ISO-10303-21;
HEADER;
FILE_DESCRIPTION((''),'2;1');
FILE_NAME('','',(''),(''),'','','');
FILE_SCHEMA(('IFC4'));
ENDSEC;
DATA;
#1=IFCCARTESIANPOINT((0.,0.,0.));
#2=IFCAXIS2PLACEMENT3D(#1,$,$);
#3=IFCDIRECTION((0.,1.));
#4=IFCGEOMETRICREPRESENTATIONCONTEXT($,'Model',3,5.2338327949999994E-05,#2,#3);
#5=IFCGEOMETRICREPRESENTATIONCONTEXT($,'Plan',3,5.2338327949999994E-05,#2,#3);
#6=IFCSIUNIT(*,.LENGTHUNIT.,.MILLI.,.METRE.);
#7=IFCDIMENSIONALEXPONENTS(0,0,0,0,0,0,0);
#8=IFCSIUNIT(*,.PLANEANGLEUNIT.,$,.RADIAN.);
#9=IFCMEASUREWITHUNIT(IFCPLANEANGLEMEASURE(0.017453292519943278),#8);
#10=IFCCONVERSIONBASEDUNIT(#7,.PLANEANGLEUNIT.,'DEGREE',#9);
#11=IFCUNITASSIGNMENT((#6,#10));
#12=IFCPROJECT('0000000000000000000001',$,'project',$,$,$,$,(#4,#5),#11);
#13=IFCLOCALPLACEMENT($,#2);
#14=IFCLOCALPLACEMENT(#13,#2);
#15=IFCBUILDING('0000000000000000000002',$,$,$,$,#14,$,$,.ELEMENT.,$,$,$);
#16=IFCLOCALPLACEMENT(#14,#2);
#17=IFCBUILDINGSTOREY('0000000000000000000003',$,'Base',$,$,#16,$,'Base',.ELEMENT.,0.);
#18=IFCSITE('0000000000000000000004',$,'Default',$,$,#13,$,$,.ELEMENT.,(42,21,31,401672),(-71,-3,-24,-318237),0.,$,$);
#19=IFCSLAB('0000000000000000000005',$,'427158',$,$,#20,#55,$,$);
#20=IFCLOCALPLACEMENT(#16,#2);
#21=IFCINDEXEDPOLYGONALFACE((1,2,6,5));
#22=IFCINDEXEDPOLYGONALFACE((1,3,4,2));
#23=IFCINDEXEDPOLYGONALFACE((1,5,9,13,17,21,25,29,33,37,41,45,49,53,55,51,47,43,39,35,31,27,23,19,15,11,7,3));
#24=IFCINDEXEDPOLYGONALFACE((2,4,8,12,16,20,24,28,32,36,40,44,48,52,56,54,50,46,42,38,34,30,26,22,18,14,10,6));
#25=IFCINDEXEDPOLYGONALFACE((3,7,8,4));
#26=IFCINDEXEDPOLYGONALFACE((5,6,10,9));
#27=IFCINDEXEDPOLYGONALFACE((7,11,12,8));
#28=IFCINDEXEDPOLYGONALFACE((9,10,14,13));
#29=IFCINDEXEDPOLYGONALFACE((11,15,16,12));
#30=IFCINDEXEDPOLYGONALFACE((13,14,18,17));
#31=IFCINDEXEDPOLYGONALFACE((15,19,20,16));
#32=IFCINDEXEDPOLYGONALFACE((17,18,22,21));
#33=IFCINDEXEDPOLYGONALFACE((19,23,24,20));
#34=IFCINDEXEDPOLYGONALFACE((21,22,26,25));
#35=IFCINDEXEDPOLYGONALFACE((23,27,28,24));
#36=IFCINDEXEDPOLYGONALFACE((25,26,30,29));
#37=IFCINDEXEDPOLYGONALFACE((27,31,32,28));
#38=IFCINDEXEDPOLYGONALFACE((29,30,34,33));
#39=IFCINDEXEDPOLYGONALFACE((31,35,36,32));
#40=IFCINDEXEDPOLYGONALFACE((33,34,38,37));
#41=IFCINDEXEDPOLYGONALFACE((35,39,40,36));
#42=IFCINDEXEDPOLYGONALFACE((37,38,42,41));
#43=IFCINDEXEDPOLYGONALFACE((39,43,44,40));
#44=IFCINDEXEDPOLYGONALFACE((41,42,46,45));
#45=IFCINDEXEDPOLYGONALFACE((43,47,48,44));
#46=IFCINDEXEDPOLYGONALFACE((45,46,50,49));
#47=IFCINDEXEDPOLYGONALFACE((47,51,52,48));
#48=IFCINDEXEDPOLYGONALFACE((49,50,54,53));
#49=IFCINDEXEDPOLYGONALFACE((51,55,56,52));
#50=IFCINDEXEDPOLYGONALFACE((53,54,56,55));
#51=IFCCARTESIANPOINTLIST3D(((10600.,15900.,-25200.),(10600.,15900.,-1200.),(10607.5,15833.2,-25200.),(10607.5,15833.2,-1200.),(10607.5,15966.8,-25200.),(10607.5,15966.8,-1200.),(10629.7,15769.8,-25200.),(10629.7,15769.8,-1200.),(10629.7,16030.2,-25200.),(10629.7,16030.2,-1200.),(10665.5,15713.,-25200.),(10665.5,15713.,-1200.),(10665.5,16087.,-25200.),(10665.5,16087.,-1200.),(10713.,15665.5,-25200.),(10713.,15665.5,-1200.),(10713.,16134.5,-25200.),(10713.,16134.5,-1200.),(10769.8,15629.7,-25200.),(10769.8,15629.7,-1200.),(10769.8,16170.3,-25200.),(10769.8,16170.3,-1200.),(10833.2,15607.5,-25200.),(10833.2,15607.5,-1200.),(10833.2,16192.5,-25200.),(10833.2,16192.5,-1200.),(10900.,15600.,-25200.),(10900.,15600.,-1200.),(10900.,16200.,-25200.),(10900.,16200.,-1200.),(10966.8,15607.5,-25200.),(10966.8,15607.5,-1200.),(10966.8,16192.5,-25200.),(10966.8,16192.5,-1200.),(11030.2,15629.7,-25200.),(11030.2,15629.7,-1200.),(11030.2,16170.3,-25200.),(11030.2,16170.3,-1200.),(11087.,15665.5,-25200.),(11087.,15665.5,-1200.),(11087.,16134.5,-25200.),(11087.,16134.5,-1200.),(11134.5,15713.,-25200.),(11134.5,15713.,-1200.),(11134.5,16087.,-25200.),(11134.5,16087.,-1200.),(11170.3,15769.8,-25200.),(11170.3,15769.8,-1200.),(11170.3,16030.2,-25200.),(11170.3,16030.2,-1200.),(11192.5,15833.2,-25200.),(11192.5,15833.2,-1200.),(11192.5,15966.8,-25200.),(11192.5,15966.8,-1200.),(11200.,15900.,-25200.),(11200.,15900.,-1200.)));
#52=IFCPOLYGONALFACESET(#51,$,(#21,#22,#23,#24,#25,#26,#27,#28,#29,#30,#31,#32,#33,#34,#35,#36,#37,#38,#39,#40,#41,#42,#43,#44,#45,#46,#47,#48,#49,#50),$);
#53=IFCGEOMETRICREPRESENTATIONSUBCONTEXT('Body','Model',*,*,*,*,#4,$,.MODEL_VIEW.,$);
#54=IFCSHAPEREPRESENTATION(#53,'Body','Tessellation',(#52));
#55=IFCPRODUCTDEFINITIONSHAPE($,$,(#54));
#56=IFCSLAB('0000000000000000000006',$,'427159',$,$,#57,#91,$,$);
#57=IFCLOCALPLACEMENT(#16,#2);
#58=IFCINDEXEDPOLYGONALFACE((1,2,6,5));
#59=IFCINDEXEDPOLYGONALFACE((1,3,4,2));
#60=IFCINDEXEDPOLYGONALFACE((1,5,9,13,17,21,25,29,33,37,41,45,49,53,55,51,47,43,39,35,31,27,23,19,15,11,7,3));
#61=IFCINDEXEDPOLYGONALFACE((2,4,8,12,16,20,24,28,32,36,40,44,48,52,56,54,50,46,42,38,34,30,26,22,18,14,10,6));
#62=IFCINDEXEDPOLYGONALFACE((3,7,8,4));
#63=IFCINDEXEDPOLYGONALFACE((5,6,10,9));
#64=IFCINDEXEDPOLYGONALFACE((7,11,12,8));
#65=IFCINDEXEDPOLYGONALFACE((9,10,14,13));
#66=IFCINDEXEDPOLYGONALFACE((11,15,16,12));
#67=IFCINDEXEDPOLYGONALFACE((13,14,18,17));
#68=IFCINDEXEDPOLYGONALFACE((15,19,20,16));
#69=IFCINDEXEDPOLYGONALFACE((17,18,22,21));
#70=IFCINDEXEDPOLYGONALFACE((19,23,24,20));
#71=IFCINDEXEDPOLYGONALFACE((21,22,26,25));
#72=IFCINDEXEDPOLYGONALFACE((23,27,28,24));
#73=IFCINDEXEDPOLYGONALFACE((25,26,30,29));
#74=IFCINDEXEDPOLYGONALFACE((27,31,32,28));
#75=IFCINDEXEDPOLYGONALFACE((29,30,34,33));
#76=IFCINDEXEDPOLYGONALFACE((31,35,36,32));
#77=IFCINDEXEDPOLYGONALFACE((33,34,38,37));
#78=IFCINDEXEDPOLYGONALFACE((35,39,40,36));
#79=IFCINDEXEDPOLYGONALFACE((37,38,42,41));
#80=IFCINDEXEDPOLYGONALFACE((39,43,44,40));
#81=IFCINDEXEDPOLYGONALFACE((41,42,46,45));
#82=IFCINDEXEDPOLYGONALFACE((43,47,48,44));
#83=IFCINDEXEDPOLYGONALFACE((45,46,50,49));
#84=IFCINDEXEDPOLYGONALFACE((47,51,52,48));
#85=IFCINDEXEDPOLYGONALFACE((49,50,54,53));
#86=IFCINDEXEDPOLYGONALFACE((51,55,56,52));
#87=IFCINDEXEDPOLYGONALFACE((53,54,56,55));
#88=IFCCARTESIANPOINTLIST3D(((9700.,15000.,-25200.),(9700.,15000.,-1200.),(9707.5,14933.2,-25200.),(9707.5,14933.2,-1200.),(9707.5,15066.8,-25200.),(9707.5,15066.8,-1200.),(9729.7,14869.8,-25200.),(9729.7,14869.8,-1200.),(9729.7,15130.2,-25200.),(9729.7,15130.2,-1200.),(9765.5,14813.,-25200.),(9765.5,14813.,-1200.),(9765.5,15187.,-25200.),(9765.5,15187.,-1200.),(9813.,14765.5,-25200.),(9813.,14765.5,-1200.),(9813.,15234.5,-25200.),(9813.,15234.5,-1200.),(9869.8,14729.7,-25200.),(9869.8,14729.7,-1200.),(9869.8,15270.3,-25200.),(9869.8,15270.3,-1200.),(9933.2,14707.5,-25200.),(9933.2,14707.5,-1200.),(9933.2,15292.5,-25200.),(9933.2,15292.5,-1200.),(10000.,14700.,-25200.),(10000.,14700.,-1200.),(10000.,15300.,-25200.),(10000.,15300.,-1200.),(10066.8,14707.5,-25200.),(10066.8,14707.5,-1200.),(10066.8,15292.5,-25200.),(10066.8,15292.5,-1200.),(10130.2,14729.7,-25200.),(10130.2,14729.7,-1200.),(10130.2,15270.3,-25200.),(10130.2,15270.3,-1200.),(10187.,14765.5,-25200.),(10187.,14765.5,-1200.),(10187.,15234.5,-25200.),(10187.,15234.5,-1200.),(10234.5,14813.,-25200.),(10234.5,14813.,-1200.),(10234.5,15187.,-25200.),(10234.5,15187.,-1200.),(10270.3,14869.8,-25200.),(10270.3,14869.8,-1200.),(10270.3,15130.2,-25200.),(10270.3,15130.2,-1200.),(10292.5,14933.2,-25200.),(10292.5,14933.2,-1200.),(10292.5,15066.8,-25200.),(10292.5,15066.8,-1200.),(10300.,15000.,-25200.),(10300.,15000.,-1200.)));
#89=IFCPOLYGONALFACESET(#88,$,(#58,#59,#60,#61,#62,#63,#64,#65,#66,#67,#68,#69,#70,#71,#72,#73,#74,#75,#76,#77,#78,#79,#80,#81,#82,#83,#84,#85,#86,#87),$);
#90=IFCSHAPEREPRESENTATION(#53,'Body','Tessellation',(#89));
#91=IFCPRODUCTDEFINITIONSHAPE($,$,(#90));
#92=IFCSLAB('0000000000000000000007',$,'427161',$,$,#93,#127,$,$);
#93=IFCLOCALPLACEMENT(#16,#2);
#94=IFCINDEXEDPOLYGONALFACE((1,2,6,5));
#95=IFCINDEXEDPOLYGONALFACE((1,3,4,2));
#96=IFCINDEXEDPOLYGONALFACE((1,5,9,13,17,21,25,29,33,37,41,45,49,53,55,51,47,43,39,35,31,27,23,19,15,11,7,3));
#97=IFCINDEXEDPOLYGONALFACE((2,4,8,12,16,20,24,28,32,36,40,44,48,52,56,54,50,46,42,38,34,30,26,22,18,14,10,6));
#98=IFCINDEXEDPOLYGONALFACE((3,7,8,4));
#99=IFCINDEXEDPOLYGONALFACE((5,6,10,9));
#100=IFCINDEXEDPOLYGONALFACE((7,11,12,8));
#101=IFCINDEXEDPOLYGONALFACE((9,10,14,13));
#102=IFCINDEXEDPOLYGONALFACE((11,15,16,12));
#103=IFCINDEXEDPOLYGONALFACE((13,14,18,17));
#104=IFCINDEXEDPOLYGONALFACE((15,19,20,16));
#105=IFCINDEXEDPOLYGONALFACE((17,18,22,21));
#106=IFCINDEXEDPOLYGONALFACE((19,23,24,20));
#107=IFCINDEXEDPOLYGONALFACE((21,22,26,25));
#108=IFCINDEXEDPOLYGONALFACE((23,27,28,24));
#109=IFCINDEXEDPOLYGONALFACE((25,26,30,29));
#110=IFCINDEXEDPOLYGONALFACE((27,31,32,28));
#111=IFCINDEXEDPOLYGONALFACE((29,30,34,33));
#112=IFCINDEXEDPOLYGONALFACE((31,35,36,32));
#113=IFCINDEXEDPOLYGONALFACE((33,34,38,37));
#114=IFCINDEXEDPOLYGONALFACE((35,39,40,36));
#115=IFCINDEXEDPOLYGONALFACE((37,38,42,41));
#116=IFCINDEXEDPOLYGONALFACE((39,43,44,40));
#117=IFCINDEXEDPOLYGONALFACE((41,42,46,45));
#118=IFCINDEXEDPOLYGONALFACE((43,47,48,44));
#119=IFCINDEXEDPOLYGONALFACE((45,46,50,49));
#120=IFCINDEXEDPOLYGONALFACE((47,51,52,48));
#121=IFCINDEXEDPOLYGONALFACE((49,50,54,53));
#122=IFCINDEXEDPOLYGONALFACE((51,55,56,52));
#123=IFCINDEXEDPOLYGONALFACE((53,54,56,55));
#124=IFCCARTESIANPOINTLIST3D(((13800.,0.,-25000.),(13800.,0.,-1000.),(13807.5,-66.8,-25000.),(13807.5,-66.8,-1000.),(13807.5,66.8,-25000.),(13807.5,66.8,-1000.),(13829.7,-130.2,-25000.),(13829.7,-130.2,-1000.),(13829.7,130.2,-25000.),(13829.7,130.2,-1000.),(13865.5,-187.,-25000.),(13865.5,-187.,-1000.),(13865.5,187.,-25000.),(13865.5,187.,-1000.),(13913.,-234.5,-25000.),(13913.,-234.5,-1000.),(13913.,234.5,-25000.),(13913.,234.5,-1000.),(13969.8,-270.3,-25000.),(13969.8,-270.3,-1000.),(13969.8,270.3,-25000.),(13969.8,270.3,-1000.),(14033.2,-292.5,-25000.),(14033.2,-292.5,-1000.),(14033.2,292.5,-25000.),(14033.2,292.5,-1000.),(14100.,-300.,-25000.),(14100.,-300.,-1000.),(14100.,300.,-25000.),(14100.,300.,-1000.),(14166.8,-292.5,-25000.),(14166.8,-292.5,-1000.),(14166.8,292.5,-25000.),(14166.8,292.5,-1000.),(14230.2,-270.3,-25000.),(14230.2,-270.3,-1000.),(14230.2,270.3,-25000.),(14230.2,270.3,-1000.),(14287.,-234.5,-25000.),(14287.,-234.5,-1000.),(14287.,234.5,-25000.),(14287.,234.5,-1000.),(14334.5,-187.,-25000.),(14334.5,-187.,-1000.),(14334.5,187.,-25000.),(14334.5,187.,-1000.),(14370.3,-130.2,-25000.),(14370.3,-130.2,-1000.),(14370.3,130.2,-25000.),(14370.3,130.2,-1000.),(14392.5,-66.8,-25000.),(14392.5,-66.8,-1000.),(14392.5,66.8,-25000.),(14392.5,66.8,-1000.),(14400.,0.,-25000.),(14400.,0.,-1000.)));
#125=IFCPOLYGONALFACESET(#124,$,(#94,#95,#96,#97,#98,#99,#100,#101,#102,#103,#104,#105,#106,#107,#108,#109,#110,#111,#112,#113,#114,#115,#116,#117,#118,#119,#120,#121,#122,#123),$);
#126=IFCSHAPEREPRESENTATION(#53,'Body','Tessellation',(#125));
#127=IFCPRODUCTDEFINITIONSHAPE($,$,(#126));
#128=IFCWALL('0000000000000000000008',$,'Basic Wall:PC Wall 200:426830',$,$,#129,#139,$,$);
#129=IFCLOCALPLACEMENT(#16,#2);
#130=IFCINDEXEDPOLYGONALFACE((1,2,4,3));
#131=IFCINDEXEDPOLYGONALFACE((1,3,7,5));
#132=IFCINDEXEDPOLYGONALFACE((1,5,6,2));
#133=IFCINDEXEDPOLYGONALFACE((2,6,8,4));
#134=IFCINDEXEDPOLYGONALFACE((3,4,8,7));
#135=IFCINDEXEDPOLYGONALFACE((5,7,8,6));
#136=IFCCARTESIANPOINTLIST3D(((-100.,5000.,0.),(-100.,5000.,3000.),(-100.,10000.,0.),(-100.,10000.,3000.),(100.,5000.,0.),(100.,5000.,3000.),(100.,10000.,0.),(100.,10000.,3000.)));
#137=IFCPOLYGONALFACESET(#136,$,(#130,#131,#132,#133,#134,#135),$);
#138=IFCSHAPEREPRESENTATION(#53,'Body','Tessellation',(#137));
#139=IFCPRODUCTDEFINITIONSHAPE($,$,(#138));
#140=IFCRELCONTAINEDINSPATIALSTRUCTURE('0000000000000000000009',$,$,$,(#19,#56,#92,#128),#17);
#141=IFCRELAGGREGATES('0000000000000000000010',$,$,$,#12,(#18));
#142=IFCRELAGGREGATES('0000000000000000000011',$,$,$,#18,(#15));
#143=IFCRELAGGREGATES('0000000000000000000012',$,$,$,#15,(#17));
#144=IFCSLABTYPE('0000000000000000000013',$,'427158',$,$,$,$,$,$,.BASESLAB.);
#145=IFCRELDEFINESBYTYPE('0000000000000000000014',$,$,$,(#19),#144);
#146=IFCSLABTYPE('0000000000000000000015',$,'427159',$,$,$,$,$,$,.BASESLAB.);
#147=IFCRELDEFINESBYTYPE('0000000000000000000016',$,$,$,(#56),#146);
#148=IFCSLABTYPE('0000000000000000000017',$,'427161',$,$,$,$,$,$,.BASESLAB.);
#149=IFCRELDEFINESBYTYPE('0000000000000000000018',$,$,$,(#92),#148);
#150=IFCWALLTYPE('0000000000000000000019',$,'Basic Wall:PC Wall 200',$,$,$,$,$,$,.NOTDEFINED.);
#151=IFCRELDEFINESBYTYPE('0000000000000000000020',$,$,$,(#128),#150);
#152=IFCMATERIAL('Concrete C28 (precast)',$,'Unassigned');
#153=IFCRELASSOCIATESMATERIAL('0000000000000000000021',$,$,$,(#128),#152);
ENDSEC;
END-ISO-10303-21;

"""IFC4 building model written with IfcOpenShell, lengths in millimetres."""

from ifc_helpers import new_model, entity, si_unit, converted_unit, direction, frame, origin, place, context, subcontext, project, spatial, arc, indexed_curve, outline, extrude, material, type_object, element, save


model = new_model("IFC4")

# Units and contexts
model_context = context("Model", 3, precision=5.2338327949999994e-05, world=origin(), true_north=direction((0.0, 1.0)))
plan_context = context("Plan", 3, precision=5.2338327949999994e-05, world=origin(), true_north=direction((0.0, 1.0)))
body_context = subcontext(model_context, "Body", "Model", "MODEL_VIEW")
ifc_project = project(units=[si_unit("LENGTHUNIT", "METRE", prefix="MILLI"), converted_unit("PLANEANGLEUNIT", "DEGREE", entity("IfcPlaneAngleMeasure", 0.017453292519943278), si_unit("PLANEANGLEUNIT", "RADIAN"), dimensions=[0, 0, 0, 0, 0, 0, 0])], contexts=[model_context, plan_context])

# Site, building, storey
site_placement = place(None, origin())
site = spatial("IfcSite", under=ifc_project, at=site_placement, Name="Default", CompositionType="ELEMENT", RefLatitude=(42, 21, 31, 401672), RefLongitude=(-71, -3, -24, -318237), RefElevation=0.0)
building_placement = place(site_placement, origin())
building = spatial("IfcBuilding", under=site, at=building_placement, CompositionType="ELEMENT")
storey_placement = place(building_placement, origin())
storey = spatial("IfcBuildingStorey", under=building, at=storey_placement, Name="Base", LongName="Base", CompositionType="ELEMENT", Elevation=0.0)

# Slabs
slab_type_1 = type_object("IfcSlabType", Name="427158", PredefinedType="BASESLAB")
slab_1_placement = place(storey_placement, origin())
element("IfcSlab", 1, at=slab_1_placement, inside=storey, type_object=slab_type_1, Name="427158", context=body_context, shape_type="SweptSolid", body=[
    extrude(outline(indexed_curve([(300.0, 0.0), (0.0, 300.0), (-300.0, 0.0), (0.0, -300.0)], segments=[arc(1, 2, 3), arc(3, 4, 1)], self_intersect=False)), frame((10900.0, 15900.0, -25200.0)), (0.0, 0.0, 1.0), 24000.0),
])
slab_type_2 = type_object("IfcSlabType", Name="427159", PredefinedType="BASESLAB")
slab_2_placement = place(storey_placement, origin())
element("IfcSlab", 2, at=slab_2_placement, inside=storey, type_object=slab_type_2, Name="427159", context=body_context, shape_type="SweptSolid", body=[
    extrude(outline(indexed_curve([(300.0, 0.0), (0.0, 300.0), (-300.0, 0.0), (0.0, -300.0)], segments=[arc(1, 2, 3), arc(3, 4, 1)], self_intersect=False)), frame((10000.0, 15000.0, -25200.0)), (0.0, 0.0, 1.0), 24000.0),
])
slab_type_3 = type_object("IfcSlabType", Name="427161", PredefinedType="BASESLAB")
slab_3_placement = place(storey_placement, origin())
element("IfcSlab", 3, at=slab_3_placement, inside=storey, type_object=slab_type_3, Name="427161", context=body_context, shape_type="SweptSolid", body=[
    extrude(outline(indexed_curve([(300.0, 0.0), (0.0, 300.0), (-300.0, 0.0), (0.0, -300.0)], segments=[arc(1, 2, 3), arc(3, 4, 1)], self_intersect=False)), frame((14100.0, 0.0, -25000.0)), (0.0, 0.0, 1.0), 24000.0),
])

# Wall
ifc_material_1 = material(Name="Concrete C28 (precast)", Category="Unassigned")
wall_type = type_object("IfcWallType", Name="Basic Wall:PC Wall 200", PredefinedType="NOTDEFINED")
wall_placement = place(storey_placement, frame((0.0, 5000.0, 0.0), z_axis=(0.0, 0.0, 1.0), x_axis=(0.0, 1.0, 0.0)))
element("IfcWall", 4, at=wall_placement, inside=storey, type_object=wall_type, material=ifc_material_1, Name="Basic Wall:PC Wall 200:426830", context=body_context, shape_type="SweptSolid", body=[
    extrude(outline(indexed_curve([(5000.0, 100.0), (0.0, 100.0), (0.0, -100.0), (5000.0, -100.0), (5000.0, 100.0)], self_intersect=False)), origin(), (0.0, 0.0, 1.0), 3000.0),
])

save(model, "model.ifc")
